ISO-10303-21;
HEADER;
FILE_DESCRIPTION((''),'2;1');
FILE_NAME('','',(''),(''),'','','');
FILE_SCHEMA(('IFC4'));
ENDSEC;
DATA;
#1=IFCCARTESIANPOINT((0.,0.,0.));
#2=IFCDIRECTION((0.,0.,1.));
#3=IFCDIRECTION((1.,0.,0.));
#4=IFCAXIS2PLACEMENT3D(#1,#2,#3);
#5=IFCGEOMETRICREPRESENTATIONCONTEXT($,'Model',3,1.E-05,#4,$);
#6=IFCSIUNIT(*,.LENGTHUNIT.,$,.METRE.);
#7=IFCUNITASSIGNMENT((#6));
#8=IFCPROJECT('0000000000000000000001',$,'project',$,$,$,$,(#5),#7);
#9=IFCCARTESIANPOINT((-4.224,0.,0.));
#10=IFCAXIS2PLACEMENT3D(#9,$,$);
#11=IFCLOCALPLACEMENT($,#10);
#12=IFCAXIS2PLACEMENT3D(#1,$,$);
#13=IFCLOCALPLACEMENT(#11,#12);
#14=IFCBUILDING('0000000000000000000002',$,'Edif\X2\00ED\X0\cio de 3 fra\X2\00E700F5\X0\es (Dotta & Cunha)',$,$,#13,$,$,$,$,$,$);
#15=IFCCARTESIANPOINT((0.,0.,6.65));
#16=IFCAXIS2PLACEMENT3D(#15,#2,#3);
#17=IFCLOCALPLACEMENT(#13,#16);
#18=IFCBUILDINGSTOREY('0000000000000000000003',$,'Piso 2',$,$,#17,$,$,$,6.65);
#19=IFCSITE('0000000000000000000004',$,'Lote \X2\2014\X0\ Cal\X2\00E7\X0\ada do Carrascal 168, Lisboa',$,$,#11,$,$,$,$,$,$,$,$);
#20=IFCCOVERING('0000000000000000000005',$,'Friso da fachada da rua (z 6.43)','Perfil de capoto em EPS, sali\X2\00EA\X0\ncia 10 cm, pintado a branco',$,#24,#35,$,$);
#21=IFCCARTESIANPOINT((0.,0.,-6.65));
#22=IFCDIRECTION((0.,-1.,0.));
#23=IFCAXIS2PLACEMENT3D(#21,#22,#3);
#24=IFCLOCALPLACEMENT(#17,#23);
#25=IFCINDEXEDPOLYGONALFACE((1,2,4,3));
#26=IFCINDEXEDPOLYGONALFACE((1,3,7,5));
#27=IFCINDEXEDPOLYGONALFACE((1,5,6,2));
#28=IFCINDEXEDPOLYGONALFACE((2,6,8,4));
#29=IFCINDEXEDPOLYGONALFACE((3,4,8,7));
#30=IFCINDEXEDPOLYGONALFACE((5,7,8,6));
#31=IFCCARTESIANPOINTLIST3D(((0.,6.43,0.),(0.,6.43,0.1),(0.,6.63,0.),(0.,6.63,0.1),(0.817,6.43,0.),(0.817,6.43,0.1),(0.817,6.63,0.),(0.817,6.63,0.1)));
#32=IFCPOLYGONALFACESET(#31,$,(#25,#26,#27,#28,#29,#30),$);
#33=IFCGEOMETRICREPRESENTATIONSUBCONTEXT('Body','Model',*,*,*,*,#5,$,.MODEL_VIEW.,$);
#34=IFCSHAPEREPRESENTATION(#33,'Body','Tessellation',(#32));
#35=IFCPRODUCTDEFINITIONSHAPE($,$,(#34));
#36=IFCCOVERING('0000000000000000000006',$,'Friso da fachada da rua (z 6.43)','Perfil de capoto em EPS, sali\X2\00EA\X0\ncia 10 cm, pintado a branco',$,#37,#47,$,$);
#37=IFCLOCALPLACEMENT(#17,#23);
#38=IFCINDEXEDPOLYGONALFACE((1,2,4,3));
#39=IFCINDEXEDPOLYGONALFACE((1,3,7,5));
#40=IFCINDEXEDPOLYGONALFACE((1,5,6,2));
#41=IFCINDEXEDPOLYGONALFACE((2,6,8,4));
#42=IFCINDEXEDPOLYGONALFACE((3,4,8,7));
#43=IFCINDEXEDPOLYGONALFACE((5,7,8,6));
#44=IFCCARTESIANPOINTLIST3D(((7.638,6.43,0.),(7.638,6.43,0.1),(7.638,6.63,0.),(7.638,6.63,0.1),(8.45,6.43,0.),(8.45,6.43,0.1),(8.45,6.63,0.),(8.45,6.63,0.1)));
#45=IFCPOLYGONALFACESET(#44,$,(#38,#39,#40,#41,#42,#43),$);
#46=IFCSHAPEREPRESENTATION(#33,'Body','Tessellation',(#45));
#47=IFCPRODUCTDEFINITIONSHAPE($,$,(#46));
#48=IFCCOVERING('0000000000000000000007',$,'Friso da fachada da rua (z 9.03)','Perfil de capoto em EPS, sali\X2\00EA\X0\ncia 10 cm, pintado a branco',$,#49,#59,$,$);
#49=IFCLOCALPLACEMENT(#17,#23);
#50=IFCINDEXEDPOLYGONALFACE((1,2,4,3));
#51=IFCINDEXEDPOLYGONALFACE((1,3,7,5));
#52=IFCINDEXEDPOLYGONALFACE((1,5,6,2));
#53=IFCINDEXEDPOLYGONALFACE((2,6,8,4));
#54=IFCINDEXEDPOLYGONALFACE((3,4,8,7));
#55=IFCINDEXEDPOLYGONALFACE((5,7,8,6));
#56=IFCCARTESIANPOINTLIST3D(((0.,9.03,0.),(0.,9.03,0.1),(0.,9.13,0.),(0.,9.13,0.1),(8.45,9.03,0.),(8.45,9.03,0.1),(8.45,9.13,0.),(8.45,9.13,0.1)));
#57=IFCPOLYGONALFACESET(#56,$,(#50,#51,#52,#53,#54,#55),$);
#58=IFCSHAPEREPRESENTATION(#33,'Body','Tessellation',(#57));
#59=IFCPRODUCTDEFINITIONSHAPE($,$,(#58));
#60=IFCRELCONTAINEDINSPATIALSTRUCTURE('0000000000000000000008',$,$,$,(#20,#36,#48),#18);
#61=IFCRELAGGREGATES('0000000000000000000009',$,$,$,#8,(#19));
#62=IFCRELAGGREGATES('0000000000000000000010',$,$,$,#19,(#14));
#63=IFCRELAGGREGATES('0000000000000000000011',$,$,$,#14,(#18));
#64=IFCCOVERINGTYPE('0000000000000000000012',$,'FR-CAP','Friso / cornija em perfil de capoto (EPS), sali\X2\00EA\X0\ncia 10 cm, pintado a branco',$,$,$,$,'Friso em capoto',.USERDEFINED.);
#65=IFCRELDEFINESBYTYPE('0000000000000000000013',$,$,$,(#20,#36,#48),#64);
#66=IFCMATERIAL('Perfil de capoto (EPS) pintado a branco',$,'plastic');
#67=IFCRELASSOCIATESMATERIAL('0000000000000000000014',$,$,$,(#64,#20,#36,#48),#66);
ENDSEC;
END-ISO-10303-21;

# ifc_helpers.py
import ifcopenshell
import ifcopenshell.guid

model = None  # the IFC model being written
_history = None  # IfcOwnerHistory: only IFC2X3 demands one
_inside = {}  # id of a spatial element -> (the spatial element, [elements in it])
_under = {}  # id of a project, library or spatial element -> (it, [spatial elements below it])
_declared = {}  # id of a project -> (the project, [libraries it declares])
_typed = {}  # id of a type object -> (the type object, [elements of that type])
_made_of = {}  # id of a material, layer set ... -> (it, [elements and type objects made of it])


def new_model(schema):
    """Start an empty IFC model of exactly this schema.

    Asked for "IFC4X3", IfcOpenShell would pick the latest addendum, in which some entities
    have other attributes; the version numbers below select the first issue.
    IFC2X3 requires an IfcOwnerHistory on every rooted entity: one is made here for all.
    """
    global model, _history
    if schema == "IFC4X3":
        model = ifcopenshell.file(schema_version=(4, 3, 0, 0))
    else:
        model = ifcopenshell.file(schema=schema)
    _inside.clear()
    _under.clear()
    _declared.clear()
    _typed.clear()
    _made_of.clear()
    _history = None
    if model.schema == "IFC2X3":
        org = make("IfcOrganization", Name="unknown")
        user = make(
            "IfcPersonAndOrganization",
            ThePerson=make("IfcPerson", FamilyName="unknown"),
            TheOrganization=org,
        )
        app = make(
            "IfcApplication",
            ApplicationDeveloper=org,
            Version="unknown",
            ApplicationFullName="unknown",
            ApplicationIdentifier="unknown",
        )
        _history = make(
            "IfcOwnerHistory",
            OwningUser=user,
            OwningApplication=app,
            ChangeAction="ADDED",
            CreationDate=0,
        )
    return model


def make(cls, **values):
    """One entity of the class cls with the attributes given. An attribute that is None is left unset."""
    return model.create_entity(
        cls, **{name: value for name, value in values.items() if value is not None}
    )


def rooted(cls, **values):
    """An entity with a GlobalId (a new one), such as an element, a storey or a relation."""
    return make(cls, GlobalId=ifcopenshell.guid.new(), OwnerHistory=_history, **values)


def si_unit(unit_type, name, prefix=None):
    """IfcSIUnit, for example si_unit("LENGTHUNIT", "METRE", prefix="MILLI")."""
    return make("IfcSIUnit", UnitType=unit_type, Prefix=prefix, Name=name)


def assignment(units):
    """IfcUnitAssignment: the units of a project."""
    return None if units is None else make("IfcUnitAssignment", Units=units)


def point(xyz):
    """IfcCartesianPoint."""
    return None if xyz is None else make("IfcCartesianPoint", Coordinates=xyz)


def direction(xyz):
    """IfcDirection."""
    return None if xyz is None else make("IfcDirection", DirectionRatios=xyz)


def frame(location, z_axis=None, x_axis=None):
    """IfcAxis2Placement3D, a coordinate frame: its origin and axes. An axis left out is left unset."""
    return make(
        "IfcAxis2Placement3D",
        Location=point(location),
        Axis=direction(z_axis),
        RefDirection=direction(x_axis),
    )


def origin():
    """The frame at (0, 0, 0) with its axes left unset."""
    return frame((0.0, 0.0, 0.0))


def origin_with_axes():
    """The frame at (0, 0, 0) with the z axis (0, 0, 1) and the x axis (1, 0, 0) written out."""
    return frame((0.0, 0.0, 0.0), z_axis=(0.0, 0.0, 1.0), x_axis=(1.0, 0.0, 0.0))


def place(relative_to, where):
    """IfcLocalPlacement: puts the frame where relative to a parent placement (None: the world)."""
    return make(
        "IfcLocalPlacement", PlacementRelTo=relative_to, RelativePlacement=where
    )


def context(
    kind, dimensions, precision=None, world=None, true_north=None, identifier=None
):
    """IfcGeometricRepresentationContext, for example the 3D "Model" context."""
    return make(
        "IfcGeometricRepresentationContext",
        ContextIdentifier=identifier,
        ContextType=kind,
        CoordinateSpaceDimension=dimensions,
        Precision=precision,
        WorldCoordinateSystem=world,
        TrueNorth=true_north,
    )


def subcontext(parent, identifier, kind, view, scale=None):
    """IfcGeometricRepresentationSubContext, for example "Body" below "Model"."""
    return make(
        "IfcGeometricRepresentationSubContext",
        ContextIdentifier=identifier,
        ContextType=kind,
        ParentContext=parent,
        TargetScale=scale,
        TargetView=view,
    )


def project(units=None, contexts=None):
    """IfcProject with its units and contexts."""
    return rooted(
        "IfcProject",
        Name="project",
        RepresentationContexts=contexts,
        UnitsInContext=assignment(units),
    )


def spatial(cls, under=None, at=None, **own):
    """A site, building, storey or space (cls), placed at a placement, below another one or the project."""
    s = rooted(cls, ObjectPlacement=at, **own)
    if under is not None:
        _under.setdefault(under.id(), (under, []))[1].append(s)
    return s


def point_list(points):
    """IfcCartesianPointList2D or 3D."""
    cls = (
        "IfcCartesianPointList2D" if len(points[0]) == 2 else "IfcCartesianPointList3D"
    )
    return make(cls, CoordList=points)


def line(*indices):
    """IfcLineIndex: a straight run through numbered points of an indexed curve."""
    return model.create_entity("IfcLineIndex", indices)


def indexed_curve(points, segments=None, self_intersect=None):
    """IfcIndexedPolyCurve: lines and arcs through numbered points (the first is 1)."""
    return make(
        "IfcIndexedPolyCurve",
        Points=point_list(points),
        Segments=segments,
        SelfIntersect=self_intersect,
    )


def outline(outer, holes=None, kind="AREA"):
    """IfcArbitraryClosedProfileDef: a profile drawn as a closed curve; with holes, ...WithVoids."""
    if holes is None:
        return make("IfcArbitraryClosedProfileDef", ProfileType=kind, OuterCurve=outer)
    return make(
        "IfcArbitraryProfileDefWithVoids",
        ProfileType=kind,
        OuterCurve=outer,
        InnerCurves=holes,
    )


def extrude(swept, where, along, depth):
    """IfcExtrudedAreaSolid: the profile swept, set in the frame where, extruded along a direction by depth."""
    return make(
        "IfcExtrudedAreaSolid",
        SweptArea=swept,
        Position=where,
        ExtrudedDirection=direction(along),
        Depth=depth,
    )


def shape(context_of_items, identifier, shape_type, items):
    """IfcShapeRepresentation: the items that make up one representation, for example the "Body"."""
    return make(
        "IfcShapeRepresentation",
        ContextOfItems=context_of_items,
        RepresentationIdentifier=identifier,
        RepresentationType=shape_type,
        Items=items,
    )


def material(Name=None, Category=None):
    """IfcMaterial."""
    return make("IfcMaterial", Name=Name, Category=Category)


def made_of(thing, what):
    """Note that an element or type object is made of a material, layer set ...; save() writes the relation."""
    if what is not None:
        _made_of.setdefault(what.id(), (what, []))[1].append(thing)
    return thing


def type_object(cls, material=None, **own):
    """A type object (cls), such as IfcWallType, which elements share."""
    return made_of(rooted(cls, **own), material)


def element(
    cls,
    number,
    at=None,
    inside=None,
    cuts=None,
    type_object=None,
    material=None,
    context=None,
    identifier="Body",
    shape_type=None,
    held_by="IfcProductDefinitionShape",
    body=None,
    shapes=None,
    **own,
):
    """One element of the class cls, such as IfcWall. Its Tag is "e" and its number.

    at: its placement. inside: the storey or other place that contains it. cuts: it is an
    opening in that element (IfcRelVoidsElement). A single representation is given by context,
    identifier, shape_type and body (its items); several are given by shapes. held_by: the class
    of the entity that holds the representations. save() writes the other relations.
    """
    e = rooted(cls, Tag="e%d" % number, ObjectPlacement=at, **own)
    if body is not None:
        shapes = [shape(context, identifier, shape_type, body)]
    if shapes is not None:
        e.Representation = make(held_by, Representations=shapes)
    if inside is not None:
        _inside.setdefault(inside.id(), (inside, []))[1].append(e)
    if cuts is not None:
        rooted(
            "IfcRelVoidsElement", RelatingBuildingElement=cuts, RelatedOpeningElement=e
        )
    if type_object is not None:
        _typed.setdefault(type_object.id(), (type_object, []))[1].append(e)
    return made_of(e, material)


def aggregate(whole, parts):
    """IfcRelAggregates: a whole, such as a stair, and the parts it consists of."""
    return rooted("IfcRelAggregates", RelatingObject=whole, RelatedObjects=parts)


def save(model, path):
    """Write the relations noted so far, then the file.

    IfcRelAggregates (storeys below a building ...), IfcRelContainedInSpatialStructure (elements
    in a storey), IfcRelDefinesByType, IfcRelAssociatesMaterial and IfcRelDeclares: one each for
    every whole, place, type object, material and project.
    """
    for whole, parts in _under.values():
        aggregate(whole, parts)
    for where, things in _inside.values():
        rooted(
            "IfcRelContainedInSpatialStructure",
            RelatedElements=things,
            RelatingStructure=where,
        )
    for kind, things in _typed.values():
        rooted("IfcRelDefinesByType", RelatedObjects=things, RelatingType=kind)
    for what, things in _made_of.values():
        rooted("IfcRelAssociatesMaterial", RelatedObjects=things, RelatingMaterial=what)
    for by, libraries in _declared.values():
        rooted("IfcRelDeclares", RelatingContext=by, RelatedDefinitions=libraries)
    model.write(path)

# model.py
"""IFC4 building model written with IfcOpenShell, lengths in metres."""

from ifc_helpers import new_model, si_unit, frame, origin, origin_with_axes, place, context, subcontext, project, spatial, line, indexed_curve, outline, extrude, material, type_object, element, save


model = new_model("IFC4")

# Units and contexts
model_context = context("Model", 3, precision=1e-05, world=origin_with_axes())
body_context = subcontext(model_context, "Body", "Model", "MODEL_VIEW")
ifc_project = project(units=[si_unit("LENGTHUNIT", "METRE")], contexts=[model_context])

# Site, building, storey
site_placement = place(None, frame((-4.224, 0.0, 0.0)))
site = spatial("IfcSite", under=ifc_project, at=site_placement, Name="Lote — Calçada do Carrascal 168, Lisboa")
building_placement = place(site_placement, origin())
building = spatial("IfcBuilding", under=site, at=building_placement, Name="Edifício de 3 frações (Dotta & Cunha)")
storey_placement = place(building_placement, frame((0.0, 0.0, 6.65), z_axis=(0.0, 0.0, 1.0), x_axis=(1.0, 0.0, 0.0)))
storey = spatial("IfcBuildingStorey", under=building, at=storey_placement, Name="Piso 2", Elevation=6.65)

# Coverings
ifc_material_1 = material(Name="Perfil de capoto (EPS) pintado a branco", Category="plastic")
covering_type_1 = type_object("IfcCoveringType", Name="FR-CAP", Description="Friso / cornija em perfil de capoto (EPS), saliência 10 cm, pintado a branco", ElementType="Friso em capoto", PredefinedType="USERDEFINED", material=ifc_material_1)
covering_1_placement = place(storey_placement, frame((0.0, 0.0, -6.65), z_axis=(0.0, -1.0, 0.0), x_axis=(1.0, 0.0, 0.0)))
element("IfcCovering", 1, at=covering_1_placement, inside=storey, type_object=covering_type_1, material=ifc_material_1, Name="Friso da fachada da rua (z 6.43)", Description="Perfil de capoto em EPS, saliência 10 cm, pintado a branco", context=body_context, shape_type="SweptSolid", body=[
    extrude(outline(indexed_curve([(0.817, 6.43), (0.817, 6.63), (0.0, 6.63), (0.0, 6.43)], segments=[line(1, 2, 3, 4, 1)])), origin_with_axes(), (0.0, 0.0, 1.0), 0.1),
])
covering_2_placement = place(storey_placement, frame((0.0, 0.0, -6.65), z_axis=(0.0, -1.0, 0.0), x_axis=(1.0, 0.0, 0.0)))
element("IfcCovering", 2, at=covering_2_placement, inside=storey, type_object=covering_type_1, material=ifc_material_1, Name="Friso da fachada da rua (z 6.43)", Description="Perfil de capoto em EPS, saliência 10 cm, pintado a branco", context=body_context, shape_type="SweptSolid", body=[
    extrude(outline(indexed_curve([(8.45, 6.43), (8.45, 6.63), (7.638, 6.63), (7.638, 6.43)], segments=[line(1, 2, 3, 4, 1)])), origin_with_axes(), (0.0, 0.0, 1.0), 0.1),
])
covering_3_placement = place(storey_placement, frame((0.0, 0.0, -6.65), z_axis=(0.0, -1.0, 0.0), x_axis=(1.0, 0.0, 0.0)))
element("IfcCovering", 3, at=covering_3_placement, inside=storey, type_object=covering_type_1, material=ifc_material_1, Name="Friso da fachada da rua (z 9.03)", Description="Perfil de capoto em EPS, saliência 10 cm, pintado a branco", context=body_context, shape_type="SweptSolid", body=[
    extrude(outline(indexed_curve([(8.45, 9.03), (8.45, 9.13), (0.0, 9.13), (0.0, 9.03)], segments=[line(1, 2, 3, 4, 1)])), origin_with_axes(), (0.0, 0.0, 1.0), 0.1),
])

save(model, "model.ifc")
